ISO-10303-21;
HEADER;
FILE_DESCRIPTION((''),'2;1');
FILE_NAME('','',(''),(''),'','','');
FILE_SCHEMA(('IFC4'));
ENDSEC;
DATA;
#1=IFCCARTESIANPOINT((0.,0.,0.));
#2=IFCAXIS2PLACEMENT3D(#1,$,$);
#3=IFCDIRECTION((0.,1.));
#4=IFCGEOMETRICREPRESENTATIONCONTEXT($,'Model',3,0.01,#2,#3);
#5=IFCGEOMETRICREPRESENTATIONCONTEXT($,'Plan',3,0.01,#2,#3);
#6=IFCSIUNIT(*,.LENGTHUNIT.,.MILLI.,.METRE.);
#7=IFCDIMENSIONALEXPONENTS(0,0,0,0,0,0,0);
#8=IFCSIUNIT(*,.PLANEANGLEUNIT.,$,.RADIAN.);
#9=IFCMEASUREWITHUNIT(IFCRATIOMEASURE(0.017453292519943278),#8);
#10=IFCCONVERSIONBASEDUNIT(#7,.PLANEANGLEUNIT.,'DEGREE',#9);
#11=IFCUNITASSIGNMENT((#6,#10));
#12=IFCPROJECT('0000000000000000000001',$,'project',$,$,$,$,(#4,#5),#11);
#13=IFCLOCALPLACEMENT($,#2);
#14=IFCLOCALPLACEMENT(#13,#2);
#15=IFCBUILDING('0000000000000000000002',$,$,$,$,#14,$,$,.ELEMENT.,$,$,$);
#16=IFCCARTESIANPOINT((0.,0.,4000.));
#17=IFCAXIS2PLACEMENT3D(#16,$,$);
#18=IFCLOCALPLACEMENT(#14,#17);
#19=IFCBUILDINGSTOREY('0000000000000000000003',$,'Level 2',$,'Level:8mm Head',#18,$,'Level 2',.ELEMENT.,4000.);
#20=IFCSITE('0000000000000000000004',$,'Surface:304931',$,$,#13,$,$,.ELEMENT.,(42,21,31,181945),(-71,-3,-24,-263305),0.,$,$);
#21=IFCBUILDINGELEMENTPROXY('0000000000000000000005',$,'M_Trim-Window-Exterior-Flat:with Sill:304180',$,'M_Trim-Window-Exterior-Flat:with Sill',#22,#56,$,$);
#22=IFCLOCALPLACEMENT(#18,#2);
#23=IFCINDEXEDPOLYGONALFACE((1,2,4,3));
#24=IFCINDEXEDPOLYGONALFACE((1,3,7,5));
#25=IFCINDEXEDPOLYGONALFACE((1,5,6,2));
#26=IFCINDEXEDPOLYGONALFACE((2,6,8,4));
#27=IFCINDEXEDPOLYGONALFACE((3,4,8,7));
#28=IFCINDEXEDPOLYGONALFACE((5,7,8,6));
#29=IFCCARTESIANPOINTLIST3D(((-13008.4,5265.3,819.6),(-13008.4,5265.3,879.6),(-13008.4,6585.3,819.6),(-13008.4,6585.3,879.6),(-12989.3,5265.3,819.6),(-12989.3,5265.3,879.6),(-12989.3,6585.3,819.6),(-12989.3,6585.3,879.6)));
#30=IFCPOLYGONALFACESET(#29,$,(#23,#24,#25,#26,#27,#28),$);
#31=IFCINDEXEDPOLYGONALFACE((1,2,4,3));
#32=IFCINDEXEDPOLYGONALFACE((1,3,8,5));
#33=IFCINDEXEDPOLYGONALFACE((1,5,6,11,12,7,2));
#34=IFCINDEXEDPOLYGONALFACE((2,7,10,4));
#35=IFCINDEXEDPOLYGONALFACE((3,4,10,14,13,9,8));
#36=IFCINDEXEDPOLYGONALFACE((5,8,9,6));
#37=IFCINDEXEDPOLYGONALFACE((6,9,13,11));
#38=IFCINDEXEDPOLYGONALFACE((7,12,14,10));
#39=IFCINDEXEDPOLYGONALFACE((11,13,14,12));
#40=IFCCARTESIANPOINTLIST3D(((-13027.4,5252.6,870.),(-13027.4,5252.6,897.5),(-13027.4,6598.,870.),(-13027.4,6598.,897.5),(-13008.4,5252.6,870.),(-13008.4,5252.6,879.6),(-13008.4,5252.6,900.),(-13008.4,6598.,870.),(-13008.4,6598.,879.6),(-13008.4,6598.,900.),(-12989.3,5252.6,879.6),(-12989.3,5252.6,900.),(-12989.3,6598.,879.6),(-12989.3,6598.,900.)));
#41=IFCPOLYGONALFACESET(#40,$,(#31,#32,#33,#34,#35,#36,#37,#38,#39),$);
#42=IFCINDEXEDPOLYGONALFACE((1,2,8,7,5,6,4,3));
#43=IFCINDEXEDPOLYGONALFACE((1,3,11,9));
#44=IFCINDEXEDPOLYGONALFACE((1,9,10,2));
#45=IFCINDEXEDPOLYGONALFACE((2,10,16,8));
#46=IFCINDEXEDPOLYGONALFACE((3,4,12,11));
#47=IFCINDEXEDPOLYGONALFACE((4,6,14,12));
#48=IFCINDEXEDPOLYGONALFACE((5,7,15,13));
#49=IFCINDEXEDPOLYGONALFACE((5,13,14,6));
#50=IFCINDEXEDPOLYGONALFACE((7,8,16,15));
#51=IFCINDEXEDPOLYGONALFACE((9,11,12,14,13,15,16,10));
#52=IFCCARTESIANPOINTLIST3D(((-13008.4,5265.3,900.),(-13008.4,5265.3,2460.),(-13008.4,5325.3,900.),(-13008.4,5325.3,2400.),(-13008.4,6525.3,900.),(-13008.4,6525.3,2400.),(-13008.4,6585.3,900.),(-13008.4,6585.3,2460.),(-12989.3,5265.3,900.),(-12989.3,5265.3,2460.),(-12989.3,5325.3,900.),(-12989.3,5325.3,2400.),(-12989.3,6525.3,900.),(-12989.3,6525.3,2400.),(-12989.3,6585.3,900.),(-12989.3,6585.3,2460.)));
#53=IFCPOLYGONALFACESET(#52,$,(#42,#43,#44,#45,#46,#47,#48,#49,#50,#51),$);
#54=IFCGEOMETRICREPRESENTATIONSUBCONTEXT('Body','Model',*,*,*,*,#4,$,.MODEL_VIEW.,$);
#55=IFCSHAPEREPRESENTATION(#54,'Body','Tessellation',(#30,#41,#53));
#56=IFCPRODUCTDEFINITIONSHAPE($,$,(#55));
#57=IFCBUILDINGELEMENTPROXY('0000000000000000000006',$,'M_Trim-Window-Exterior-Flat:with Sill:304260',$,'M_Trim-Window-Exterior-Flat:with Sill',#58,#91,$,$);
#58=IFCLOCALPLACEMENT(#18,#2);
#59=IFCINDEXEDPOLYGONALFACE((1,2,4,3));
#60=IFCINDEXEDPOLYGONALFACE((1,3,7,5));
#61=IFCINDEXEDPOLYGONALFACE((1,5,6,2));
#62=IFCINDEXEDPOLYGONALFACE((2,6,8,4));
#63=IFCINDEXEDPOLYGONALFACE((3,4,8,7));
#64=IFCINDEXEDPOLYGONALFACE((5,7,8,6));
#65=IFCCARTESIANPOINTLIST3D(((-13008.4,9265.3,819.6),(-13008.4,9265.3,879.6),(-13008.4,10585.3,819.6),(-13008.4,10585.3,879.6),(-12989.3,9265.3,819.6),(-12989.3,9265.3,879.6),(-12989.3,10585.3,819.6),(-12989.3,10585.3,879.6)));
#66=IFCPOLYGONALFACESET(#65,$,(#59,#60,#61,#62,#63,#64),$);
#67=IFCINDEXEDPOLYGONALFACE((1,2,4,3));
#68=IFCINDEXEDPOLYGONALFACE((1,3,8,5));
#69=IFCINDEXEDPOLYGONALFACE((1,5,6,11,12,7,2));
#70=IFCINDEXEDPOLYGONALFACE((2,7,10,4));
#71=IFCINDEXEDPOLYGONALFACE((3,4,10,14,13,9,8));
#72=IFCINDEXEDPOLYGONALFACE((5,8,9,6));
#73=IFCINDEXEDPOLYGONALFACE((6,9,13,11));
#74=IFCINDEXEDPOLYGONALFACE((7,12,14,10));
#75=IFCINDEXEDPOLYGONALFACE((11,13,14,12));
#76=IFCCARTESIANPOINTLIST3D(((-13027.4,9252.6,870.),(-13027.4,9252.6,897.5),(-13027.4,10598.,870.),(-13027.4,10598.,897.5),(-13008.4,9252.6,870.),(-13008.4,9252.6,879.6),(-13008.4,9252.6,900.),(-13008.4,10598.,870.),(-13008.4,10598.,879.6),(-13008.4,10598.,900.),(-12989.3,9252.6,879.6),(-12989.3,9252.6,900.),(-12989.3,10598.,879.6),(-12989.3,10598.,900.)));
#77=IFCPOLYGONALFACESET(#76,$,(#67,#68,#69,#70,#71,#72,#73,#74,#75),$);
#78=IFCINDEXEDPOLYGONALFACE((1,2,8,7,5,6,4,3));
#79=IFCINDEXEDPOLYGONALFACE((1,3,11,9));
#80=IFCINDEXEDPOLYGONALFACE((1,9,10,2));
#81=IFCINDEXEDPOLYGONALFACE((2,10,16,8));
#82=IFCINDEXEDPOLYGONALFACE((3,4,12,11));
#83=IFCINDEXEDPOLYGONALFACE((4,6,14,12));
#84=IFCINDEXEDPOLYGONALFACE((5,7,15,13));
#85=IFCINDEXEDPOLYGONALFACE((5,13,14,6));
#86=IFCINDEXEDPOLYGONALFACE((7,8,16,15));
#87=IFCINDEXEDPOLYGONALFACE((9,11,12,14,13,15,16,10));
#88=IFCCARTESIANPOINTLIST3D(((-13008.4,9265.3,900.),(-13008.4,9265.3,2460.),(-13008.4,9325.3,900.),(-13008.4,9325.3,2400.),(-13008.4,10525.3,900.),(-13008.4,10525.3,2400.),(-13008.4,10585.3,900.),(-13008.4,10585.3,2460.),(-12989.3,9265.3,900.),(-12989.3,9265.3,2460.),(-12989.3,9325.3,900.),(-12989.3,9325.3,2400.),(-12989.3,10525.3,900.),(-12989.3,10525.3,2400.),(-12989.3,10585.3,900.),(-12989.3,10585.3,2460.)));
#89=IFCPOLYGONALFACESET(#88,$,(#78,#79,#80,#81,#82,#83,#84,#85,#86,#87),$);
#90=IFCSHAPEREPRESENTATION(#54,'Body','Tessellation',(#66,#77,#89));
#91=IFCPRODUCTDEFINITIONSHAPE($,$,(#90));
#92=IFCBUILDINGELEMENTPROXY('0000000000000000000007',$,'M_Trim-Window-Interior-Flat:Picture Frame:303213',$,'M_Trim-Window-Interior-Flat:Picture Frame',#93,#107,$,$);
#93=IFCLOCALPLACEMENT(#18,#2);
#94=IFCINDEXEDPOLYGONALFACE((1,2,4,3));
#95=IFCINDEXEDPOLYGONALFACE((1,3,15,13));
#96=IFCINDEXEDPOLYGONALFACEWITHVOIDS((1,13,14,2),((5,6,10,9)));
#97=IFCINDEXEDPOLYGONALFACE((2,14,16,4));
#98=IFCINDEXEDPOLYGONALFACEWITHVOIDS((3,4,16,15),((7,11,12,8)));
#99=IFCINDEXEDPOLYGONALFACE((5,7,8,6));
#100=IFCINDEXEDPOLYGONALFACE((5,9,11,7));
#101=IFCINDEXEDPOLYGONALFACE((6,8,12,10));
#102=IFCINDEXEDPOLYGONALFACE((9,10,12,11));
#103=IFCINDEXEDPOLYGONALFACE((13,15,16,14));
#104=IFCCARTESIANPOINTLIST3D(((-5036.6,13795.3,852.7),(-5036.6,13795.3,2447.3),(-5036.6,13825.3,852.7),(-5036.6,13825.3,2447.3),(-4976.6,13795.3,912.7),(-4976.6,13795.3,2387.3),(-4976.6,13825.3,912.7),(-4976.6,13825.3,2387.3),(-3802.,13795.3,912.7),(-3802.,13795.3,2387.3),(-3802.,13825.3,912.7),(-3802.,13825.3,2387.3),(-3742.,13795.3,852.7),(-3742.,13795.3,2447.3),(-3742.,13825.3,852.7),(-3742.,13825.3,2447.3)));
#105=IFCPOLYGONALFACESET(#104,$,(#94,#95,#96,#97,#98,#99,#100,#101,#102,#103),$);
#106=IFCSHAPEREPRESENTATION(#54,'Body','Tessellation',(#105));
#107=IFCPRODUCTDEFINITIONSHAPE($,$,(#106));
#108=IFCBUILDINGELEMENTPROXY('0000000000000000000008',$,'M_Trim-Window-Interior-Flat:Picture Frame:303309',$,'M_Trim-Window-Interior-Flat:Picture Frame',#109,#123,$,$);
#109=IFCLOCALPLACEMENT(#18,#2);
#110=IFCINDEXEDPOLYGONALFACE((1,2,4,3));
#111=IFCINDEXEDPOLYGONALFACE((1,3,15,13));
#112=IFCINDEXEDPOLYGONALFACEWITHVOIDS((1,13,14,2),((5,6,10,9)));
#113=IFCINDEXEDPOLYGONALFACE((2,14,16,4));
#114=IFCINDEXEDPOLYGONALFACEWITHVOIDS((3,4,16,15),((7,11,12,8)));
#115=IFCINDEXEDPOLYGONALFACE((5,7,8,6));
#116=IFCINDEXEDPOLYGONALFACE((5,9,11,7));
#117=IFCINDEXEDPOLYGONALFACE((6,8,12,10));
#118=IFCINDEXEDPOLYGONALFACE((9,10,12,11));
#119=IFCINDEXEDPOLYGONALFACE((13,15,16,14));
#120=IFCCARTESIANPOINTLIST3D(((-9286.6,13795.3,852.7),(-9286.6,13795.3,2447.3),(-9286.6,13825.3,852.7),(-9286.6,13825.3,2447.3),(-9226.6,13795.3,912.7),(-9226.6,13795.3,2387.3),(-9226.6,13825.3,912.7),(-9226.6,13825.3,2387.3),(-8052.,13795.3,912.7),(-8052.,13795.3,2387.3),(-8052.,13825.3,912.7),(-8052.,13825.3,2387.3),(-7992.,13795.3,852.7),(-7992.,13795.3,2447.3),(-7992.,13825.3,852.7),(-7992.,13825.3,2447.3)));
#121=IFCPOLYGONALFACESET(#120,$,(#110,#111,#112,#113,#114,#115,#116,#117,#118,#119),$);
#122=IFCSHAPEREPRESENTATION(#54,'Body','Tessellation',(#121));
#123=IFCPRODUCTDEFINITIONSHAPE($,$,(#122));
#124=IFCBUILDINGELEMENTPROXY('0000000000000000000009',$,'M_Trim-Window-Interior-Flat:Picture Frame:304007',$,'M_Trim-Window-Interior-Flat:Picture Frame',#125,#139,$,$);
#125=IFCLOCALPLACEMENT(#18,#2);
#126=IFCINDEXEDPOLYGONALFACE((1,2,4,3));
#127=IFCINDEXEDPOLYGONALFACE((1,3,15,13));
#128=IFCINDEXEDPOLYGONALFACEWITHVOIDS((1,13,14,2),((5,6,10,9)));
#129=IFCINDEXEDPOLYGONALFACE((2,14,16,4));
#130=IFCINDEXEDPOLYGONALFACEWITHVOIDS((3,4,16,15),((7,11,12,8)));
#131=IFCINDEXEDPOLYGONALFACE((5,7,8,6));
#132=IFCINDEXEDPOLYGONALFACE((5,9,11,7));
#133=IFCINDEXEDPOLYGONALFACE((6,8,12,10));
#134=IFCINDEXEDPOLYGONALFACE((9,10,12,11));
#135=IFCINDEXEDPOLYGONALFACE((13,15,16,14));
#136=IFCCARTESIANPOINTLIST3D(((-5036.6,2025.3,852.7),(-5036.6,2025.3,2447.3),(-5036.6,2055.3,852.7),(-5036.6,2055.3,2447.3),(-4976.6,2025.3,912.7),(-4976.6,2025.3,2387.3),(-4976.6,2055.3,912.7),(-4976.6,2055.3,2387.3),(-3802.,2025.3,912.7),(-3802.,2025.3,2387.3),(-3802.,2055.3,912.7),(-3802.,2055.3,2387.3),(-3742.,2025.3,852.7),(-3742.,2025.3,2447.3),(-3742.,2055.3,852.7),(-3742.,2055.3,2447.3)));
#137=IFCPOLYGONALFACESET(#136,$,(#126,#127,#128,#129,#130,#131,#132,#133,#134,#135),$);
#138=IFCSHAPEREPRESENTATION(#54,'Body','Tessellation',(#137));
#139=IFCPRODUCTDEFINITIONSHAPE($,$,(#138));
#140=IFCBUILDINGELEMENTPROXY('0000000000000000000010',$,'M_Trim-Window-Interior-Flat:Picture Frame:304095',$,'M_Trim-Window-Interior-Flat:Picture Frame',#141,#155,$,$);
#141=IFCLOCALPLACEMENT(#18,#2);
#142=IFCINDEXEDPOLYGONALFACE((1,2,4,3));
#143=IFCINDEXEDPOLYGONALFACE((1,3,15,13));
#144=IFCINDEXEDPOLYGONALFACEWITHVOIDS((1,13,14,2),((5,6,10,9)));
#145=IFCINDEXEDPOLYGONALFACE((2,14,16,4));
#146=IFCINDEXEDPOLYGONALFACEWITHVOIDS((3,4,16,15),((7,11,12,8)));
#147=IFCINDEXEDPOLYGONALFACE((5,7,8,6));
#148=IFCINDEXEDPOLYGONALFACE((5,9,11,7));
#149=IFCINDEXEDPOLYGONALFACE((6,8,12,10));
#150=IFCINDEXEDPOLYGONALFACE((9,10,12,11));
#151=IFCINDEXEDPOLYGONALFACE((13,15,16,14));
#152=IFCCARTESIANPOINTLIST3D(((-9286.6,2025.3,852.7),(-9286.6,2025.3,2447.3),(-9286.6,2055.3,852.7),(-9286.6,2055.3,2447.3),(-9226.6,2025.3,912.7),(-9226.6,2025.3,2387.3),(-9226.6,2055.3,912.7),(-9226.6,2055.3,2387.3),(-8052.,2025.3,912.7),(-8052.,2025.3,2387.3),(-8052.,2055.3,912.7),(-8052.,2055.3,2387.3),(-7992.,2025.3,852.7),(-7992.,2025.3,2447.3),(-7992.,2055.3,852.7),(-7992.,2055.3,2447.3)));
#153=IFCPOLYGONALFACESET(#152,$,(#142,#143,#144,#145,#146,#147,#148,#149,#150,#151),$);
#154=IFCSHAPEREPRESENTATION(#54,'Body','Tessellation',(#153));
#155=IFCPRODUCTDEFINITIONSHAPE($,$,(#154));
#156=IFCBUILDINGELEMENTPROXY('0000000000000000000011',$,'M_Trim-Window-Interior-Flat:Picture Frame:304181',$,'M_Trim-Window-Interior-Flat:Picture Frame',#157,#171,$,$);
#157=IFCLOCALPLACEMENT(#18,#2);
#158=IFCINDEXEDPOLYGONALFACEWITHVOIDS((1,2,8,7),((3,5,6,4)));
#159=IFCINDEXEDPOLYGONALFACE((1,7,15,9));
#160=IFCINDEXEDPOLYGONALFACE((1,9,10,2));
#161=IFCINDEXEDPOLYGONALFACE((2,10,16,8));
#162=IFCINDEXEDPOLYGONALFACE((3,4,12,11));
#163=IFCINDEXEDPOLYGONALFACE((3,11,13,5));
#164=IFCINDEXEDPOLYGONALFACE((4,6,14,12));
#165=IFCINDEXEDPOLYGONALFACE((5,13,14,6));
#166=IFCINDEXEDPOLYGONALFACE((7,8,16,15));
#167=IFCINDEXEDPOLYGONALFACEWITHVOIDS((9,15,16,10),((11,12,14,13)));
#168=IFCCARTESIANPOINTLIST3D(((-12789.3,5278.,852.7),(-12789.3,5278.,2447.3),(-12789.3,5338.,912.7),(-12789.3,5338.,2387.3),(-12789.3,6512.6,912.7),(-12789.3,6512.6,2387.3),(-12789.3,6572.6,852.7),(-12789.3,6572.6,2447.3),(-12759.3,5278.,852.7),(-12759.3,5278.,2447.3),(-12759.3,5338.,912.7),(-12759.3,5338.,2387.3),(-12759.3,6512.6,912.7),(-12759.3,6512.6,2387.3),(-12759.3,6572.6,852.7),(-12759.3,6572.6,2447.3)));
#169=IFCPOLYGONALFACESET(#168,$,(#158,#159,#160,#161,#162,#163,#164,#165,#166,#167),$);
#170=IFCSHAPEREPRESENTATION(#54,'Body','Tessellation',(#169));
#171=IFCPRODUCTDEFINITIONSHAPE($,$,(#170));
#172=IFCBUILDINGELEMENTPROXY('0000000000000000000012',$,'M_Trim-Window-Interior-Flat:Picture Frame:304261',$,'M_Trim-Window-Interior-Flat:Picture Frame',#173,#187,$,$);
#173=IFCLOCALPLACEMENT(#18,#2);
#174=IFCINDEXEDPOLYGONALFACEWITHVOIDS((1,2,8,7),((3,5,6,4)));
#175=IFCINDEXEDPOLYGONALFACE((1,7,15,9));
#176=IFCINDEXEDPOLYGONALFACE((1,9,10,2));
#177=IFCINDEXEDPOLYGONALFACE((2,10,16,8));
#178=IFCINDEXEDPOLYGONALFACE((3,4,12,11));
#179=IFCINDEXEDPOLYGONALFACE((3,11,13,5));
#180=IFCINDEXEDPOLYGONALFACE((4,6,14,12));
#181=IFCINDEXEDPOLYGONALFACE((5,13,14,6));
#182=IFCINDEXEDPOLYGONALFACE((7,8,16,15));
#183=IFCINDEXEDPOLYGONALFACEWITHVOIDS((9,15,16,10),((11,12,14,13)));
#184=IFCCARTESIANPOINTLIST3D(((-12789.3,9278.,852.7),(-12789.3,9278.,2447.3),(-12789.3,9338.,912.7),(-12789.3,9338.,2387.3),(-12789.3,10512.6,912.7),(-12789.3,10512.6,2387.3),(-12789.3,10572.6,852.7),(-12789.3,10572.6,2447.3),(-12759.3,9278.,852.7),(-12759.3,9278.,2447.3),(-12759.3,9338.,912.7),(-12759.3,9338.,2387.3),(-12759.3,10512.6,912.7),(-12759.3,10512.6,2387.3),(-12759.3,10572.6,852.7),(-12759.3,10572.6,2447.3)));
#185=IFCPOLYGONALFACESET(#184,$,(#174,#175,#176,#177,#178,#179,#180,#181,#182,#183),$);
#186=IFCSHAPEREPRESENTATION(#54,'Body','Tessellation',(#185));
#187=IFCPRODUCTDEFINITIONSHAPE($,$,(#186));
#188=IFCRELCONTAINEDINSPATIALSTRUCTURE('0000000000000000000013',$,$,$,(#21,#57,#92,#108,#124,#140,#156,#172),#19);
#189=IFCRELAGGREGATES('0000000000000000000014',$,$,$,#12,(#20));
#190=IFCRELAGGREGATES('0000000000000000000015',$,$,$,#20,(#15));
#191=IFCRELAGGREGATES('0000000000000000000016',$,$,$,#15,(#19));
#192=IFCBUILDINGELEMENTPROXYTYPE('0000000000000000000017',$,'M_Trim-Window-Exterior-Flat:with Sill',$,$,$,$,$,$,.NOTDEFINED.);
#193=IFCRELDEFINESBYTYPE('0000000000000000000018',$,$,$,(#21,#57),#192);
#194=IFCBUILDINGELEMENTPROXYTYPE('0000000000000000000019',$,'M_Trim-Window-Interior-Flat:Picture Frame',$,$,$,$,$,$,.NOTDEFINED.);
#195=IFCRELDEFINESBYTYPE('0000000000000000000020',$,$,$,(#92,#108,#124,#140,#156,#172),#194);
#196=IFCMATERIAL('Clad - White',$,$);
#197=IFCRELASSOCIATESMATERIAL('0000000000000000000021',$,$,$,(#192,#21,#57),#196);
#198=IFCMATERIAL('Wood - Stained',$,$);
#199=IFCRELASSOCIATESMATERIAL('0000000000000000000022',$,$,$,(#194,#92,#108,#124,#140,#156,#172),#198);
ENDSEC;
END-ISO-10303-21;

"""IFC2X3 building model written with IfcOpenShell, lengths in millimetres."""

from ifc_helpers import new_model, entity, si_unit, converted_unit, direction, frame, frame_2d, origin, place, context, subcontext, project, spatial, polyline, rectangle, outline, extrude, source, transform, mapped, material, type_object, type_shapes, element, save


model = new_model("IFC2X3")

# Units and contexts
model_context = context("Model", 3, precision=0.01, world=origin(), true_north=direction((0.0, 1.0)))
plan_context = context("Plan", 3, precision=0.01, world=origin(), true_north=direction((0.0, 1.0)))
body_context = subcontext(model_context, "Body", "Model", "MODEL_VIEW")
ifc_project = project(units=[si_unit("LENGTHUNIT", "METRE", prefix="MILLI"), converted_unit("PLANEANGLEUNIT", "DEGREE", entity("IfcRatioMeasure", 0.017453292519943278), si_unit("PLANEANGLEUNIT", "RADIAN"), dimensions=[0, 0, 0, 0, 0, 0, 0])], contexts=[model_context, plan_context])

# Site, building, storey
site_placement = place(None, origin())
site = spatial("IfcSite", under=ifc_project, at=site_placement, Name="Surface:304931", CompositionType="ELEMENT", RefLatitude=(42, 21, 31, 181945), RefLongitude=(-71, -3, -24, -263305), RefElevation=0.0)
building_placement = place(site_placement, origin())
building = spatial("IfcBuilding", under=site, at=building_placement, CompositionType="ELEMENT")
storey_placement = place(building_placement, frame((0.0, 0.0, 4000.0)))
storey = spatial("IfcBuildingStorey", under=building, at=storey_placement, Name="Level 2", ObjectType="Level:8mm Head", LongName="Level 2", CompositionType="ELEMENT", Elevation=4000.0)

# Building element proxies
ifc_material_1 = material(Name="Clad - White")
ifc_material_2 = material(Name="Wood - Stained")
building_element_proxy_type_1 = type_object("IfcBuildingElementProxyType", Name="M_Trim-Window-Exterior-Flat:with Sill", PredefinedType="NOTDEFINED", material=ifc_material_1)
shared_shape_1 = source(origin(), body_context, "Body", "SweptSolid", [
    extrude(rectangle(XDim=1320.0, YDim=60.0, at=frame_2d((0.0, 0.0), x_axis=(1.0, 0.0))), frame((0.0, -1550.4, 0.0), z_axis=(0.0, 0.0, 1.0), x_axis=(-1.0, 0.0, 0.0)), (0.0, 0.0, 1.0), 19.0),
    extrude(outline(polyline([(-19.0, -15.2), (0.0, -15.2), (0.0, -5.7), (19.0, -5.7), (19.0, 14.8), (0.0, 14.8), (-19.0, 12.3), (-19.0, -15.2)])), frame((-672.7, -1514.8, 19.0), z_axis=(1.0, 0.0, 0.0), x_axis=(0.0, 0.0, -1.0)), (0.0, 0.0, 1.0), 1345.4),
    extrude(outline(polyline([(-795.0, -660.0), (765.0, -660.0), (765.0, -600.0), (-735.0, -600.0), (-735.0, 600.0), (765.0, 600.0), (765.0, 660.0), (-795.0, 660.0), (-795.0, -660.0)])), frame((0.0, -735.0, 0.0), z_axis=(0.0, 0.0, 1.0), x_axis=(0.0, -1.0, 0.0)), (0.0, 0.0, 1.0), 19.0),
])
type_shapes(building_element_proxy_type_1, [shared_shape_1])
for number, where, z_axis, x_axis, name in (
    (1, (-12989.3, 5925.3, 2400.0), (-1.0, 0.0, 0.0), (0.0, -1.0, 0.0), "M_Trim-Window-Exterior-Flat:with Sill:304180"),
    (2, (-12989.3, 9925.3, 2400.0), (-1.0, 0.0, 0.0), (0.0, -1.0, 0.0), "M_Trim-Window-Exterior-Flat:with Sill:304260"),
):
    element("IfcBuildingElementProxy", number, at=place(storey_placement, frame(where, z_axis=z_axis, x_axis=x_axis)), inside=storey, type_object=building_element_proxy_type_1, material=ifc_material_1, Name=name, ObjectType="M_Trim-Window-Exterior-Flat:with Sill", context=body_context, shape_type="MappedRepresentation", body=[
        mapped(shared_shape_1, transform((0.0, 0.0, 0.0), scale=1.0)),
    ])
building_element_proxy_type_2 = type_object("IfcBuildingElementProxyType", Name="M_Trim-Window-Interior-Flat:Picture Frame", PredefinedType="NOTDEFINED", material=ifc_material_2)
shared_shape_2 = source(origin(), body_context, "Body", "SweptSolid", [
    extrude(outline(polyline([(-647.3, -797.3), (647.3, -797.3), (647.3, 797.3), (-647.3, 797.3), (-647.3, -797.3)]), holes=[polyline([(-587.3, -737.3), (-587.3, 737.3), (587.3, 737.3), (587.3, -737.3), (-587.3, -737.3)])]), frame((0.0, -750.0, 0.0), z_axis=(0.0, 0.0, 1.0), x_axis=(-1.0, 0.0, 0.0)), (0.0, 0.0, 1.0), 30.0),
])
type_shapes(building_element_proxy_type_2, [shared_shape_2])
for number, where, z_axis, x_axis, name in (
    (3, (-4389.3, 13825.3, 2400.0), (0.0, -1.0, 0.0), (1.0, 0.0, 0.0), "M_Trim-Window-Interior-Flat:Picture Frame:303213"),
    (4, (-8639.3, 13825.3, 2400.0), (0.0, -1.0, 0.0), (1.0, 0.0, 0.0), "M_Trim-Window-Interior-Flat:Picture Frame:303309"),
    (5, (-4389.3, 2025.3, 2400.0), (0.0, 1.0, 0.0), (-1.0, 0.0, 0.0), "M_Trim-Window-Interior-Flat:Picture Frame:304007"),
    (6, (-8639.3, 2025.3, 2400.0), (0.0, 1.0, 0.0), (-1.0, 0.0, 0.0), "M_Trim-Window-Interior-Flat:Picture Frame:304095"),
    (7, (-12789.3, 5925.3, 2400.0), (1.0, 0.0, 0.0), (0.0, 1.0, 0.0), "M_Trim-Window-Interior-Flat:Picture Frame:304181"),
    (8, (-12789.3, 9925.3, 2400.0), (1.0, 0.0, 0.0), (0.0, 1.0, 0.0), "M_Trim-Window-Interior-Flat:Picture Frame:304261"),
):
    element("IfcBuildingElementProxy", number, at=place(storey_placement, frame(where, z_axis=z_axis, x_axis=x_axis)), inside=storey, type_object=building_element_proxy_type_2, material=ifc_material_2, Name=name, ObjectType="M_Trim-Window-Interior-Flat:Picture Frame", context=body_context, shape_type="MappedRepresentation", body=[
        mapped(shared_shape_2, transform((0.0, 0.0, 0.0), scale=1.0)),
    ])

save(model, "model.ifc")
